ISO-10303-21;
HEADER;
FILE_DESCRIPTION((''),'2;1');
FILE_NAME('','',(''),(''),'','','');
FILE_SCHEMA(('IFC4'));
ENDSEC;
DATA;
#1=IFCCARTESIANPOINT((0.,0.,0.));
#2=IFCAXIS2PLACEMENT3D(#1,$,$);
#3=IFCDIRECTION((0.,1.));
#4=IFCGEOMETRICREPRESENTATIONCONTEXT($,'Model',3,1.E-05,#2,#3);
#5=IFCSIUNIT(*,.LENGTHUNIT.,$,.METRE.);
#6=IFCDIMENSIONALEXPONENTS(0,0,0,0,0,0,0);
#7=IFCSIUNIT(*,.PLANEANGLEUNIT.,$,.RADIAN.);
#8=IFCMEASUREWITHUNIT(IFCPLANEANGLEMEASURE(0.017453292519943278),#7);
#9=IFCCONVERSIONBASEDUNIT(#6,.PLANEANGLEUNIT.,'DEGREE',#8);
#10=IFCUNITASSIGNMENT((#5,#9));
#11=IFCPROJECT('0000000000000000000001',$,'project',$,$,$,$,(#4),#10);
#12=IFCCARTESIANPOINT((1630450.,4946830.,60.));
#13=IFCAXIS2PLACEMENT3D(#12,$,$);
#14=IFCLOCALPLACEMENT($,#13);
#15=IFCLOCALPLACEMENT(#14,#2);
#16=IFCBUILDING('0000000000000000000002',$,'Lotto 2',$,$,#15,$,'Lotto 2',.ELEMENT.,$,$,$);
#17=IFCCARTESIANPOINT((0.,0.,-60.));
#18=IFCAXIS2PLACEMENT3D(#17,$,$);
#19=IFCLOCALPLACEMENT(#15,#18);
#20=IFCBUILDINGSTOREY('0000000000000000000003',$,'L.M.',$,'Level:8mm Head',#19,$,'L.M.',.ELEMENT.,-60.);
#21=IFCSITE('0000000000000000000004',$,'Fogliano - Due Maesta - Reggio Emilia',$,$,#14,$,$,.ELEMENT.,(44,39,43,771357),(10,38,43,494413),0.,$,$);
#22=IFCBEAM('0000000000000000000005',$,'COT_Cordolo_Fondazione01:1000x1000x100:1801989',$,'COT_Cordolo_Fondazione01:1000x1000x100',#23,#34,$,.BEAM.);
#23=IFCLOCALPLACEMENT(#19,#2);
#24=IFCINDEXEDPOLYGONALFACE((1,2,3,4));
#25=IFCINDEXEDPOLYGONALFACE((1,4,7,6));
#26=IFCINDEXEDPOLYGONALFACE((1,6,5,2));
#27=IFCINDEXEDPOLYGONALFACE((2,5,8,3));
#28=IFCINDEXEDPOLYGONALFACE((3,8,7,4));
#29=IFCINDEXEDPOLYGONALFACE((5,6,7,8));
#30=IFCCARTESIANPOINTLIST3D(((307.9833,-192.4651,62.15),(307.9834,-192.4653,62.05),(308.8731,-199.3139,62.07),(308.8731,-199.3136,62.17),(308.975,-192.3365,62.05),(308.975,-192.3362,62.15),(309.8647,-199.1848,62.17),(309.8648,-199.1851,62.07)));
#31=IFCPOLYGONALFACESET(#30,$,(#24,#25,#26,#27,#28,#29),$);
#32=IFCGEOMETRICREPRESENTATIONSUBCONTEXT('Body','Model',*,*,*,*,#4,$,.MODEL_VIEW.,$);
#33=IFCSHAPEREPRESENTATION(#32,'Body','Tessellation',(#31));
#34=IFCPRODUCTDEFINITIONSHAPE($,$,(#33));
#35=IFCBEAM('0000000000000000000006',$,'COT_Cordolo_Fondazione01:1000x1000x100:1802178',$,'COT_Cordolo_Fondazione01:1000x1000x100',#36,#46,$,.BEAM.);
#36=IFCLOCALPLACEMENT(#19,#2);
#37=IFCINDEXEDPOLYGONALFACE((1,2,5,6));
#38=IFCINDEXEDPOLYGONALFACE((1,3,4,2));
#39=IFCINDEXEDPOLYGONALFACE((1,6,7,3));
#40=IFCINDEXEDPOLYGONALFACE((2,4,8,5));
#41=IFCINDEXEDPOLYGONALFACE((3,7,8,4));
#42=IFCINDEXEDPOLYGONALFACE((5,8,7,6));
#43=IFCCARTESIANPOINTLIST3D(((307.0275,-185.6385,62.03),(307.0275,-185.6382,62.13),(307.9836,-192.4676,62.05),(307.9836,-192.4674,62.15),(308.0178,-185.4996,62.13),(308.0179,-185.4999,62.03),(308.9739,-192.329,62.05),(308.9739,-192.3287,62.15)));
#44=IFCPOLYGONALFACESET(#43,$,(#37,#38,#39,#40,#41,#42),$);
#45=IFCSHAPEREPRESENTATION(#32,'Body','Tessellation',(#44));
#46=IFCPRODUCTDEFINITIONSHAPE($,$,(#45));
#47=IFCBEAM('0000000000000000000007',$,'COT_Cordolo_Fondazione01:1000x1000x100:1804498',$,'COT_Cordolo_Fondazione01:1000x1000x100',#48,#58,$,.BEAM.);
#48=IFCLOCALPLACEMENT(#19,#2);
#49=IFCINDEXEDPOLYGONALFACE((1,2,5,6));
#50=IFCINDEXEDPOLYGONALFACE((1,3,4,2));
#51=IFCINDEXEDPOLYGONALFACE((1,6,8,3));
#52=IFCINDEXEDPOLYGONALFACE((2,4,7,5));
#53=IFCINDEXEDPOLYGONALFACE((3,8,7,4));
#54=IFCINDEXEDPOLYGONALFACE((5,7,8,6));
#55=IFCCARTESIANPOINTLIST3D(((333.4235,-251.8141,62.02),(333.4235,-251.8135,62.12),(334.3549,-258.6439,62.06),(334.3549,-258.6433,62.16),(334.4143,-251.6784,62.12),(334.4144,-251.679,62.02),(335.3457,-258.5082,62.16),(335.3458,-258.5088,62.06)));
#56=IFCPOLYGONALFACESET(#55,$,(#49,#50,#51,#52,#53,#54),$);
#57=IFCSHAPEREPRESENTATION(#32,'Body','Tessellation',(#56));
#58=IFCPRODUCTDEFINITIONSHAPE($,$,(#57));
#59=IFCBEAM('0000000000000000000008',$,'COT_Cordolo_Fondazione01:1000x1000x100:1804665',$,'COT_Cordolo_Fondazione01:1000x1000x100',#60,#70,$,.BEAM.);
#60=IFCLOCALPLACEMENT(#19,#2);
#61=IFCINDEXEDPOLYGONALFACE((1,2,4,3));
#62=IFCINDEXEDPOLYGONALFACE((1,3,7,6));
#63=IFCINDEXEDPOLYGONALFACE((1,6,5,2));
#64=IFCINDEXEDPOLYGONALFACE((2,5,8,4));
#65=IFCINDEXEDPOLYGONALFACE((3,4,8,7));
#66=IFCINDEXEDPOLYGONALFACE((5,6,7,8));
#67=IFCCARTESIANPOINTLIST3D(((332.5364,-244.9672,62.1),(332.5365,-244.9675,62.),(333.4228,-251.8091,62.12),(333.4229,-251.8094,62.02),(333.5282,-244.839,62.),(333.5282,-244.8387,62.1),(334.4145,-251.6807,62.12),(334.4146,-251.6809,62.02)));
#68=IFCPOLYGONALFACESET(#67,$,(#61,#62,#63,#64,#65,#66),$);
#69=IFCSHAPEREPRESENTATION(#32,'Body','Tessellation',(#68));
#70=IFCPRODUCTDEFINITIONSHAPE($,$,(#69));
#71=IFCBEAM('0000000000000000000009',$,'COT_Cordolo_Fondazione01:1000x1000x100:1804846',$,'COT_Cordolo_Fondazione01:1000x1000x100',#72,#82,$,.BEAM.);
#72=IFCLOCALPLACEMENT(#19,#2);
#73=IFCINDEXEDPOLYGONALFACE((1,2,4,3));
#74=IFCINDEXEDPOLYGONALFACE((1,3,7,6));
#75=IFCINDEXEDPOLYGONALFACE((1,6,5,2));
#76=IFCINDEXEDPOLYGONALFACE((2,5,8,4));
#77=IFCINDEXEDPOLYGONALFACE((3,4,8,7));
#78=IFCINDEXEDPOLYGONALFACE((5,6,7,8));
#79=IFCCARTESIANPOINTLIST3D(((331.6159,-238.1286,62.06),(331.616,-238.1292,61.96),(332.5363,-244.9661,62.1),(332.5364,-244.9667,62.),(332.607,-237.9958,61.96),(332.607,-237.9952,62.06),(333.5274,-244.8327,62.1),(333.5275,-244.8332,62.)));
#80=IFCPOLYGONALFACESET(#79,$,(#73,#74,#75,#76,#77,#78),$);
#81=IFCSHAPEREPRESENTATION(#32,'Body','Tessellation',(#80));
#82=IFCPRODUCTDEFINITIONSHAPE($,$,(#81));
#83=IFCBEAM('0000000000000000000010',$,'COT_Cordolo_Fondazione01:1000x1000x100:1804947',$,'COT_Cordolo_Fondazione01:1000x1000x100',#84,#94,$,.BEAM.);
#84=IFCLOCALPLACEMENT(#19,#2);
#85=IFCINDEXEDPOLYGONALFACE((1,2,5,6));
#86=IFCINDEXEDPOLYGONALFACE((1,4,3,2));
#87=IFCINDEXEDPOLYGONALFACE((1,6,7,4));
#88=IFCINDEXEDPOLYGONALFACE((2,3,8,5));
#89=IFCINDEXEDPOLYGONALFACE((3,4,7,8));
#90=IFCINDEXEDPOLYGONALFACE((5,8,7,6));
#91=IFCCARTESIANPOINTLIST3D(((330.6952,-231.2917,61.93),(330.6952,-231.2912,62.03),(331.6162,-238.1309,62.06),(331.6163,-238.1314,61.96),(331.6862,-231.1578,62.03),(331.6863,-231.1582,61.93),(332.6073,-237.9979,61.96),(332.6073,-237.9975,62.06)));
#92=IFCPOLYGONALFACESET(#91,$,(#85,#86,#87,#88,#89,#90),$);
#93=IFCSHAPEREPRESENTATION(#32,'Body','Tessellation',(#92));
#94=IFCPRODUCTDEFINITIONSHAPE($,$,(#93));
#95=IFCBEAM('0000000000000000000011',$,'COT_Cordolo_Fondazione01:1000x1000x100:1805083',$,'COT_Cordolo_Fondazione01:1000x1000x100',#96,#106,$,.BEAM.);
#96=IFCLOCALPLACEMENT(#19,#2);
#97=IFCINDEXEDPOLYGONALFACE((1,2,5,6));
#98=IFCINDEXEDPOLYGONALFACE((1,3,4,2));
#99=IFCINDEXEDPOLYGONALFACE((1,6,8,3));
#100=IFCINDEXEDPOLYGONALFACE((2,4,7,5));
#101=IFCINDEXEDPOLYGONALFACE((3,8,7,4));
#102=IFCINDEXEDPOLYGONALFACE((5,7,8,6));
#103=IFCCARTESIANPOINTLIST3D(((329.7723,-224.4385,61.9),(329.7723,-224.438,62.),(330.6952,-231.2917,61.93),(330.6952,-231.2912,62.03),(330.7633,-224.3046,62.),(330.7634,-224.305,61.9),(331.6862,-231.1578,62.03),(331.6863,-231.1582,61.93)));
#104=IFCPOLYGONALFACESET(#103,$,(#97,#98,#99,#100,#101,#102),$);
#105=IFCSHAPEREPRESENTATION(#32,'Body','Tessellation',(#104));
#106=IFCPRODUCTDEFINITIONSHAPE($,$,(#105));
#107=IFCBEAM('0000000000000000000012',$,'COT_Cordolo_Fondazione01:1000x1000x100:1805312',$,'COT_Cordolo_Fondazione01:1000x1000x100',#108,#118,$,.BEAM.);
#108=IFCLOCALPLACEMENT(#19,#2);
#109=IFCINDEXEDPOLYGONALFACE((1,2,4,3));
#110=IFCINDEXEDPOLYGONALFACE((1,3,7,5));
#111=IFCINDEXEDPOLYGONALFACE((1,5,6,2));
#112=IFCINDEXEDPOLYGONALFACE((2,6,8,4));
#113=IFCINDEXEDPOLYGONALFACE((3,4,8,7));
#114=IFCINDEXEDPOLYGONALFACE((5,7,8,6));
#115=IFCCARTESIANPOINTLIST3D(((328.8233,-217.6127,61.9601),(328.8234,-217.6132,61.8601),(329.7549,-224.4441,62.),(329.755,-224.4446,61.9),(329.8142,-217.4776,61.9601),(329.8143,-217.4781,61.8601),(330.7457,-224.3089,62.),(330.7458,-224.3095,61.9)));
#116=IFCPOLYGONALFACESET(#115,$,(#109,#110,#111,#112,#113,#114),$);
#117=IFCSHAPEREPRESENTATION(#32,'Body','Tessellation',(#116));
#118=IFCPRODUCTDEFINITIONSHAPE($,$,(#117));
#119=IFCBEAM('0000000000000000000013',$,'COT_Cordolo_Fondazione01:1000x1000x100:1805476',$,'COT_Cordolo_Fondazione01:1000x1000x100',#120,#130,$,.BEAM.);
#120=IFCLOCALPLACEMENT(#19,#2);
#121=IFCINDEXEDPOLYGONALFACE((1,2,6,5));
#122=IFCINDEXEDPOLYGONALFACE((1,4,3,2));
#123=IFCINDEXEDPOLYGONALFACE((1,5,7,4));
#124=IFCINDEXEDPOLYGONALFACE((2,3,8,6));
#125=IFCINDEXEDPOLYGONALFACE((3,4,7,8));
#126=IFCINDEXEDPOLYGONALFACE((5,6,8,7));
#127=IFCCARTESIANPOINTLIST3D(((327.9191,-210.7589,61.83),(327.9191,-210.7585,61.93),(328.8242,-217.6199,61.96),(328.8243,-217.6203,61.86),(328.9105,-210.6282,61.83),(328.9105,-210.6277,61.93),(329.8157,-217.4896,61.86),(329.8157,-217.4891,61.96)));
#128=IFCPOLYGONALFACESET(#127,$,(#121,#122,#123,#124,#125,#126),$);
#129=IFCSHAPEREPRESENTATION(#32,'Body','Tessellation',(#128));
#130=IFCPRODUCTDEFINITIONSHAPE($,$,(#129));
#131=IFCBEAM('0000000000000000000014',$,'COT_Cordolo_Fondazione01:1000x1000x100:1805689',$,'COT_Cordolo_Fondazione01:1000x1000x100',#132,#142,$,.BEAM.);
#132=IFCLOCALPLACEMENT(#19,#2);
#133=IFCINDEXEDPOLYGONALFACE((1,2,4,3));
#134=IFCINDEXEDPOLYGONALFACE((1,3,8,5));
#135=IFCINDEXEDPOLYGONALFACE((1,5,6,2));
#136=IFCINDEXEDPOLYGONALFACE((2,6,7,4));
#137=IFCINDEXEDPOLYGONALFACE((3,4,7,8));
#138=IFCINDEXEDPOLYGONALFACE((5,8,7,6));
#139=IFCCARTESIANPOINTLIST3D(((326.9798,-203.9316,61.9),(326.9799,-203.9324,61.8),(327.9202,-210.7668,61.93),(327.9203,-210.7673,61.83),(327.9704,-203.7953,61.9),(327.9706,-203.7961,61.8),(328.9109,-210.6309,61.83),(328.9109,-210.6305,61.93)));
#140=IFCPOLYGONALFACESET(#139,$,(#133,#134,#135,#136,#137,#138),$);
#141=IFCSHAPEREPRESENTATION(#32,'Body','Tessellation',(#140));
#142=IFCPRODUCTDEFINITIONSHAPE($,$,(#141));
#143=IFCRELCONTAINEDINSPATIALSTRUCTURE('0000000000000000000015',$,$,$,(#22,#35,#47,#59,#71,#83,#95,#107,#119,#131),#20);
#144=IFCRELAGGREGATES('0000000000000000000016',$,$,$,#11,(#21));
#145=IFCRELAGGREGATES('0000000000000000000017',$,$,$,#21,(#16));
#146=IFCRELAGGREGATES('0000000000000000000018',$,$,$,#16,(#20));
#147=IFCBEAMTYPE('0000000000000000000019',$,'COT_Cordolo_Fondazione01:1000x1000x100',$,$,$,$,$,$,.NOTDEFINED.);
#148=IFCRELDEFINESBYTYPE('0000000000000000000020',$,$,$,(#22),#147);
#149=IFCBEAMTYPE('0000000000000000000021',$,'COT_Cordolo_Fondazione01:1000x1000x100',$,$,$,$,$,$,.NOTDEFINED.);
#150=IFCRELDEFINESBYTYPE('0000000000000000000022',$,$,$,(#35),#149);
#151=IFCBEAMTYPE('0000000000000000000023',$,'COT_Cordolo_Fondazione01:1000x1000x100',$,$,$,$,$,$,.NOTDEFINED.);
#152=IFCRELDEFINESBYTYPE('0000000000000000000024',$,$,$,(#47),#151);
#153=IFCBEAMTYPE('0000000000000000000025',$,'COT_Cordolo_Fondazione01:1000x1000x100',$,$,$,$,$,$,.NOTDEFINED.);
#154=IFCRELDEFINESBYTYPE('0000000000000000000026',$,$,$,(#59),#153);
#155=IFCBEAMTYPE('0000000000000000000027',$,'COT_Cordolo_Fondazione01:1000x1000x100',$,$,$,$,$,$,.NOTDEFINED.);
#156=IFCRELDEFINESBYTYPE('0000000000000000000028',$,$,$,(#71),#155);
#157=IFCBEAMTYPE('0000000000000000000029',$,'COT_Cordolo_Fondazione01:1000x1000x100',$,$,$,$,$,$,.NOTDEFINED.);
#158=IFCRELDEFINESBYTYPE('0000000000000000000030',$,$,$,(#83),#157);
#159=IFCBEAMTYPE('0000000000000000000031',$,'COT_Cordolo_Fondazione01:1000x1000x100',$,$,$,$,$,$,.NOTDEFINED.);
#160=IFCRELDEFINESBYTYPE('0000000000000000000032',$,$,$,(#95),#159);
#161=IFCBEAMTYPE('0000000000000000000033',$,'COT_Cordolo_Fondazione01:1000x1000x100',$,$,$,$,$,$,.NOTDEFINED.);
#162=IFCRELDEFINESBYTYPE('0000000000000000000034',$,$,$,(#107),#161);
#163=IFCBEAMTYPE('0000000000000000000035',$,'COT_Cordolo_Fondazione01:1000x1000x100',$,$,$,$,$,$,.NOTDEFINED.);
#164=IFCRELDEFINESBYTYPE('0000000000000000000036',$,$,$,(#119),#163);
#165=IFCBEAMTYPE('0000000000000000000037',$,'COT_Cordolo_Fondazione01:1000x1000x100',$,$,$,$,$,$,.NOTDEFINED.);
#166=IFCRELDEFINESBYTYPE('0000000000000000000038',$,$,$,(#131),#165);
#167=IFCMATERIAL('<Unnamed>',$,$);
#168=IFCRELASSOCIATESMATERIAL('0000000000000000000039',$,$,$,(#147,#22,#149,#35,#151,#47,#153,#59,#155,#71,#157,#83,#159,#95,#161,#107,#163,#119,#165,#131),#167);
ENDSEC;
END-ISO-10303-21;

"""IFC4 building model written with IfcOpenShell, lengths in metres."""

from ifc_helpers import new_model, entity, si_unit, converted_unit, direction, frame, origin, place, context, subcontext, project, spatial, indexed_curve, outline, extrude, source, transform, mapped, material, type_object, type_shapes, element, save


model = new_model("IFC4")

# Units and contexts
model_context = context("Model", 3, precision=1e-05, world=origin(), true_north=direction((0.0, 1.0)))
body_context = subcontext(model_context, "Body", "Model", "MODEL_VIEW")
ifc_project = project(units=[si_unit("LENGTHUNIT", "METRE"), converted_unit("PLANEANGLEUNIT", "DEGREE", entity("IfcPlaneAngleMeasure", 0.017453292519943278), si_unit("PLANEANGLEUNIT", "RADIAN"), dimensions=[0, 0, 0, 0, 0, 0, 0])], contexts=[model_context])

# Site, building, storey
site_placement = place(None, frame((1630450.0, 4946830.0, 60.0)))
site = spatial("IfcSite", under=ifc_project, at=site_placement, Name="Fogliano - Due Maesta - Reggio Emilia", CompositionType="ELEMENT", RefLatitude=(44, 39, 43, 771357), RefLongitude=(10, 38, 43, 494413), RefElevation=0.0)
building_placement = place(site_placement, origin())
building = spatial("IfcBuilding", under=site, at=building_placement, Name="Lotto 2", LongName="Lotto 2", CompositionType="ELEMENT")
storey_placement = place(building_placement, frame((0.0, 0.0, -60.0)))
storey = spatial("IfcBuildingStorey", under=building, at=storey_placement, Name="L.M.", ObjectType="Level:8mm Head", LongName="L.M.", CompositionType="ELEMENT", Elevation=-60.0)

# Beams
ifc_material_1 = material(Name="<Unnamed>")
beam_type_1 = type_object("IfcBeamType", Name="COT_Cordolo_Fondazione01:1000x1000x100", PredefinedType="NOTDEFINED", material=ifc_material_1)
shared_shape_1 = source(origin(), body_context, "Body", "SweptSolid", [
    extrude(outline(indexed_curve([(-3.4531, -0.5), (3.4531, -0.5), (3.4531, 0.5), (-3.4531, 0.5), (-3.4531, -0.5)], self_intersect=False)), frame((0.0037, 0.0, -0.05), z_axis=(0.0, 0.0, 1.0), x_axis=(-1.0, 0.0, 0.0)), (0.0, 0.0, 1.0), 0.1),
])
type_shapes(beam_type_1, [shared_shape_1])
beam_1_placement = place(storey_placement, frame((308.9245, -195.8287, 62.11), z_axis=(-0.000373, 0.002874, 0.999996), x_axis=(-0.128833, 0.991662, -0.002899)))
element("IfcBeam", 1, at=beam_1_placement, inside=storey, type_object=beam_type_1, material=ifc_material_1, Name="COT_Cordolo_Fondazione01:1000x1000x100:1801989", ObjectType="COT_Cordolo_Fondazione01:1000x1000x100", PredefinedType="BEAM", context=body_context, shape_type="MappedRepresentation", body=[
    mapped(shared_shape_1, transform((0.0, 0.0, 0.0), scale=1.0)),
])
beam_type_2 = type_object("IfcBeamType", Name="COT_Cordolo_Fondazione01:1000x1000x100", PredefinedType="NOTDEFINED", material=ifc_material_1)
shared_shape_2 = source(origin(), body_context, "Body", "SweptSolid", [
    extrude(outline(indexed_curve([(-3.4479, -0.5), (3.4479, -0.5), (3.4479, 0.5), (-3.4479, 0.5), (-3.4479, -0.5)], self_intersect=False)), frame((-0.0016, 0.0, -0.05), z_axis=(0.0, 0.0, 1.0), x_axis=(-1.0, 0.0, 0.0)), (0.0, 0.0, 1.0), 0.1),
])
type_shapes(beam_type_2, [shared_shape_2])
beam_2_placement = place(storey_placement, frame((308.0005, -188.9821, 62.09), z_axis=(-0.000402, 0.002871, 0.999996), x_axis=(-0.138647, 0.990338, -0.002899)))
element("IfcBeam", 2, at=beam_2_placement, inside=storey, type_object=beam_type_2, material=ifc_material_1, Name="COT_Cordolo_Fondazione01:1000x1000x100:1802178", ObjectType="COT_Cordolo_Fondazione01:1000x1000x100", PredefinedType="BEAM", context=body_context, shape_type="MappedRepresentation", body=[
    mapped(shared_shape_2, transform((0.0, 0.0, 0.0), scale=1.0)),
])
beam_type_3 = type_object("IfcBeamType", Name="COT_Cordolo_Fondazione01:1000x1000x100", PredefinedType="NOTDEFINED", material=ifc_material_1)
shared_shape_3 = source(origin(), body_context, "Body", "SweptSolid", [
    extrude(outline(indexed_curve([(-0.05, -0.5), (0.05, -0.5), (0.05, 0.5), (-0.05, 0.5), (-0.05, -0.5)], self_intersect=False)), frame((334.8503, -258.5761, 2.11), z_axis=(-0.13512, 0.990812, -0.005806), x_axis=(0.000784, -0.005752, -0.999983)), (0.0, 0.0, 1.0), 6.8931),
])
type_shapes(beam_type_3, [shared_shape_3])
beam_3_placement = place(storey_placement, frame((0.0, 0.0, 60.0)))
element("IfcBeam", 3, at=beam_3_placement, inside=storey, type_object=beam_type_3, material=ifc_material_1, Name="COT_Cordolo_Fondazione01:1000x1000x100:1804498", ObjectType="COT_Cordolo_Fondazione01:1000x1000x100", PredefinedType="BEAM", context=body_context, shape_type="MappedRepresentation", body=[
    mapped(shared_shape_3, transform((0.0, 0.0, 0.0), scale=1.0)),
])
beam_type_4 = type_object("IfcBeamType", Name="COT_Cordolo_Fondazione01:1000x1000x100", PredefinedType="NOTDEFINED", material=ifc_material_1)
shared_shape_4 = source(origin(), body_context, "Body", "SweptSolid", [
    extrude(outline(indexed_curve([(-0.05, -0.5), (0.05, -0.5), (0.05, 0.5), (-0.05, 0.5), (-0.05, -0.5)], self_intersect=False)), frame((333.9187, -251.745, 2.07), z_axis=(-0.128477, 0.991708, -0.002903), x_axis=(0.000373, -0.002879, -0.999996)), (0.0, 0.0, 1.0), 6.8992),
])
type_shapes(beam_type_4, [shared_shape_4])
beam_4_placement = place(storey_placement, frame((0.0, 0.0, 60.0)))
element("IfcBeam", 4, at=beam_4_placement, inside=storey, type_object=beam_type_4, material=ifc_material_1, Name="COT_Cordolo_Fondazione01:1000x1000x100:1804665", ObjectType="COT_Cordolo_Fondazione01:1000x1000x100", PredefinedType="BEAM", context=body_context, shape_type="MappedRepresentation", body=[
    mapped(shared_shape_4, transform((0.0, 0.0, 0.0), scale=1.0)),
])
beam_type_5 = type_object("IfcBeamType", Name="COT_Cordolo_Fondazione01:1000x1000x100", PredefinedType="NOTDEFINED", material=ifc_material_1)
shared_shape_5 = source(origin(), body_context, "Body", "SweptSolid", [
    extrude(outline(indexed_curve([(-0.05, -0.5), (0.05, -0.5), (0.05, 0.5), (-0.05, 0.5), (-0.05, -0.5)], self_intersect=False)), frame((333.0319, -244.8997, 2.05), z_axis=(-0.133411, 0.991044, -0.005797), x_axis=(0.000773, -0.005745, -0.999983)), (0.0, 0.0, 1.0), 6.8993),
])
type_shapes(beam_type_5, [shared_shape_5])
beam_5_placement = place(storey_placement, frame((0.0, 0.0, 60.0)))
element("IfcBeam", 5, at=beam_5_placement, inside=storey, type_object=beam_type_5, material=ifc_material_1, Name="COT_Cordolo_Fondazione01:1000x1000x100:1804846", ObjectType="COT_Cordolo_Fondazione01:1000x1000x100", PredefinedType="BEAM", context=body_context, shape_type="MappedRepresentation", body=[
    mapped(shared_shape_5, transform((0.0, 0.0, 0.0), scale=1.0)),
])
beam_type_6 = type_object("IfcBeamType", Name="COT_Cordolo_Fondazione01:1000x1000x100", PredefinedType="NOTDEFINED", material=ifc_material_1)
shared_shape_6 = source(origin(), body_context, "Body", "SweptSolid", [
    extrude(outline(indexed_curve([(-0.05, -0.5), (0.05, -0.5), (0.05, 0.5), (-0.05, 0.5), (-0.05, -0.5)], self_intersect=False)), frame((332.1118, -238.0644, 2.01), z_axis=(-0.133458, 0.991045, -0.004348), x_axis=(0.00058, -0.004309, -0.999991)), (0.0, 0.0, 1.0), 6.9015),
])
type_shapes(beam_type_6, [shared_shape_6])
beam_6_placement = place(storey_placement, frame((0.0, 0.0, 60.0)))
element("IfcBeam", 6, at=beam_6_placement, inside=storey, type_object=beam_type_6, material=ifc_material_1, Name="COT_Cordolo_Fondazione01:1000x1000x100:1804947", ObjectType="COT_Cordolo_Fondazione01:1000x1000x100", PredefinedType="BEAM", context=body_context, shape_type="MappedRepresentation", body=[
    mapped(shared_shape_6, transform((0.0, 0.0, 0.0), scale=1.0)),
])
beam_type_7 = type_object("IfcBeamType", Name="COT_Cordolo_Fondazione01:1000x1000x100", PredefinedType="NOTDEFINED", material=ifc_material_1)
shared_shape_7 = source(origin(), body_context, "Body", "SweptSolid", [
    extrude(outline(indexed_curve([(-0.05, -0.5), (0.05, -0.5), (0.05, 0.5), (-0.05, 0.5), (-0.05, -0.5)], self_intersect=False)), frame((331.1907, -231.2247, 1.98), z_axis=(-0.133458, 0.991045, -0.004335), x_axis=(0.000579, -0.004296, -0.999991)), (0.0, 0.0, 1.0), 6.9151),
])
type_shapes(beam_type_7, [shared_shape_7])
beam_7_placement = place(storey_placement, frame((0.0, 0.0, 60.0)))
element("IfcBeam", 7, at=beam_7_placement, inside=storey, type_object=beam_type_7, material=ifc_material_1, Name="COT_Cordolo_Fondazione01:1000x1000x100:1805083", ObjectType="COT_Cordolo_Fondazione01:1000x1000x100", PredefinedType="BEAM", context=body_context, shape_type="MappedRepresentation", body=[
    mapped(shared_shape_7, transform((0.0, 0.0, 0.0), scale=1.0)),
])
beam_type_8 = type_object("IfcBeamType", Name="COT_Cordolo_Fondazione01:1000x1000x100", PredefinedType="NOTDEFINED", material=ifc_material_1)
shared_shape_8 = source(origin(), body_context, "Body", "SweptSolid", [
    extrude(outline(indexed_curve([(-0.05, -0.5), (0.05, -0.5), (0.05, 0.5), (-0.05, 0.5), (-0.05, -0.5)], self_intersect=False)), frame((330.2504, -224.3768, 1.95), z_axis=(-0.135111, 0.990814, -0.005797), x_axis=(0.000783, -0.005744, -0.999983)), (0.0, 0.0, 1.0), 6.8947),
])
type_shapes(beam_type_8, [shared_shape_8])
beam_8_placement = place(storey_placement, frame((0.0, 0.0, 60.0)))
element("IfcBeam", 8, at=beam_8_placement, inside=storey, type_object=beam_type_8, material=ifc_material_1, Name="COT_Cordolo_Fondazione01:1000x1000x100:1805312", ObjectType="COT_Cordolo_Fondazione01:1000x1000x100", PredefinedType="BEAM", context=body_context, shape_type="MappedRepresentation", body=[
    mapped(shared_shape_8, transform((0.0, 0.0, 0.0), scale=1.0)),
])
beam_type_9 = type_object("IfcBeamType", Name="COT_Cordolo_Fondazione01:1000x1000x100", PredefinedType="NOTDEFINED", material=ifc_material_1)
shared_shape_9 = source(origin(), body_context, "Body", "SweptSolid", [
    extrude(outline(indexed_curve([(-0.05, -0.5), (0.05, -0.5), (0.05, 0.5), (-0.05, 0.5), (-0.05, -0.5)], self_intersect=False)), frame((329.32, -217.5547, 1.91), z_axis=(-0.130788, 0.991401, -0.004339), x_axis=(0.000567, -0.004301, -0.999991)), (0.0, 0.0, 1.0), 6.9209),
])
type_shapes(beam_type_9, [shared_shape_9])
beam_9_placement = place(storey_placement, frame((0.0, 0.0, 60.0)))
element("IfcBeam", 9, at=beam_9_placement, inside=storey, type_object=beam_type_9, material=ifc_material_1, Name="COT_Cordolo_Fondazione01:1000x1000x100:1805476", ObjectType="COT_Cordolo_Fondazione01:1000x1000x100", PredefinedType="BEAM", context=body_context, shape_type="MappedRepresentation", body=[
    mapped(shared_shape_9, transform((0.0, 0.0, 0.0), scale=1.0)),
])
beam_type_10 = type_object("IfcBeamType", Name="COT_Cordolo_Fondazione01:1000x1000x100", PredefinedType="NOTDEFINED", material=ifc_material_1)
shared_shape_10 = source(origin(), body_context, "Body", "SweptSolid", [
    extrude(outline(indexed_curve([(-3.45, -0.05), (3.4497, -0.05), (3.4497, 0.05), (-3.4495, 0.05), (-3.45, -0.05)], self_intersect=False)), frame((327.45, -207.3495, 1.865), z_axis=(0.990667, 0.136302, 0.0), x_axis=(0.136301, -0.990658, 0.004357)), (0.0, 0.0, 1.0), 1.0),
])
type_shapes(beam_type_10, [shared_shape_10])
beam_10_placement = place(storey_placement, frame((0.0, 0.0, 60.0)))
element("IfcBeam", 10, at=beam_10_placement, inside=storey, type_object=beam_type_10, material=ifc_material_1, Name="COT_Cordolo_Fondazione01:1000x1000x100:1805689", ObjectType="COT_Cordolo_Fondazione01:1000x1000x100", PredefinedType="BEAM", context=body_context, shape_type="MappedRepresentation", body=[
    mapped(shared_shape_10, transform((0.0, 0.0, 0.0), scale=1.0)),
])

save(model, "model.ifc")
